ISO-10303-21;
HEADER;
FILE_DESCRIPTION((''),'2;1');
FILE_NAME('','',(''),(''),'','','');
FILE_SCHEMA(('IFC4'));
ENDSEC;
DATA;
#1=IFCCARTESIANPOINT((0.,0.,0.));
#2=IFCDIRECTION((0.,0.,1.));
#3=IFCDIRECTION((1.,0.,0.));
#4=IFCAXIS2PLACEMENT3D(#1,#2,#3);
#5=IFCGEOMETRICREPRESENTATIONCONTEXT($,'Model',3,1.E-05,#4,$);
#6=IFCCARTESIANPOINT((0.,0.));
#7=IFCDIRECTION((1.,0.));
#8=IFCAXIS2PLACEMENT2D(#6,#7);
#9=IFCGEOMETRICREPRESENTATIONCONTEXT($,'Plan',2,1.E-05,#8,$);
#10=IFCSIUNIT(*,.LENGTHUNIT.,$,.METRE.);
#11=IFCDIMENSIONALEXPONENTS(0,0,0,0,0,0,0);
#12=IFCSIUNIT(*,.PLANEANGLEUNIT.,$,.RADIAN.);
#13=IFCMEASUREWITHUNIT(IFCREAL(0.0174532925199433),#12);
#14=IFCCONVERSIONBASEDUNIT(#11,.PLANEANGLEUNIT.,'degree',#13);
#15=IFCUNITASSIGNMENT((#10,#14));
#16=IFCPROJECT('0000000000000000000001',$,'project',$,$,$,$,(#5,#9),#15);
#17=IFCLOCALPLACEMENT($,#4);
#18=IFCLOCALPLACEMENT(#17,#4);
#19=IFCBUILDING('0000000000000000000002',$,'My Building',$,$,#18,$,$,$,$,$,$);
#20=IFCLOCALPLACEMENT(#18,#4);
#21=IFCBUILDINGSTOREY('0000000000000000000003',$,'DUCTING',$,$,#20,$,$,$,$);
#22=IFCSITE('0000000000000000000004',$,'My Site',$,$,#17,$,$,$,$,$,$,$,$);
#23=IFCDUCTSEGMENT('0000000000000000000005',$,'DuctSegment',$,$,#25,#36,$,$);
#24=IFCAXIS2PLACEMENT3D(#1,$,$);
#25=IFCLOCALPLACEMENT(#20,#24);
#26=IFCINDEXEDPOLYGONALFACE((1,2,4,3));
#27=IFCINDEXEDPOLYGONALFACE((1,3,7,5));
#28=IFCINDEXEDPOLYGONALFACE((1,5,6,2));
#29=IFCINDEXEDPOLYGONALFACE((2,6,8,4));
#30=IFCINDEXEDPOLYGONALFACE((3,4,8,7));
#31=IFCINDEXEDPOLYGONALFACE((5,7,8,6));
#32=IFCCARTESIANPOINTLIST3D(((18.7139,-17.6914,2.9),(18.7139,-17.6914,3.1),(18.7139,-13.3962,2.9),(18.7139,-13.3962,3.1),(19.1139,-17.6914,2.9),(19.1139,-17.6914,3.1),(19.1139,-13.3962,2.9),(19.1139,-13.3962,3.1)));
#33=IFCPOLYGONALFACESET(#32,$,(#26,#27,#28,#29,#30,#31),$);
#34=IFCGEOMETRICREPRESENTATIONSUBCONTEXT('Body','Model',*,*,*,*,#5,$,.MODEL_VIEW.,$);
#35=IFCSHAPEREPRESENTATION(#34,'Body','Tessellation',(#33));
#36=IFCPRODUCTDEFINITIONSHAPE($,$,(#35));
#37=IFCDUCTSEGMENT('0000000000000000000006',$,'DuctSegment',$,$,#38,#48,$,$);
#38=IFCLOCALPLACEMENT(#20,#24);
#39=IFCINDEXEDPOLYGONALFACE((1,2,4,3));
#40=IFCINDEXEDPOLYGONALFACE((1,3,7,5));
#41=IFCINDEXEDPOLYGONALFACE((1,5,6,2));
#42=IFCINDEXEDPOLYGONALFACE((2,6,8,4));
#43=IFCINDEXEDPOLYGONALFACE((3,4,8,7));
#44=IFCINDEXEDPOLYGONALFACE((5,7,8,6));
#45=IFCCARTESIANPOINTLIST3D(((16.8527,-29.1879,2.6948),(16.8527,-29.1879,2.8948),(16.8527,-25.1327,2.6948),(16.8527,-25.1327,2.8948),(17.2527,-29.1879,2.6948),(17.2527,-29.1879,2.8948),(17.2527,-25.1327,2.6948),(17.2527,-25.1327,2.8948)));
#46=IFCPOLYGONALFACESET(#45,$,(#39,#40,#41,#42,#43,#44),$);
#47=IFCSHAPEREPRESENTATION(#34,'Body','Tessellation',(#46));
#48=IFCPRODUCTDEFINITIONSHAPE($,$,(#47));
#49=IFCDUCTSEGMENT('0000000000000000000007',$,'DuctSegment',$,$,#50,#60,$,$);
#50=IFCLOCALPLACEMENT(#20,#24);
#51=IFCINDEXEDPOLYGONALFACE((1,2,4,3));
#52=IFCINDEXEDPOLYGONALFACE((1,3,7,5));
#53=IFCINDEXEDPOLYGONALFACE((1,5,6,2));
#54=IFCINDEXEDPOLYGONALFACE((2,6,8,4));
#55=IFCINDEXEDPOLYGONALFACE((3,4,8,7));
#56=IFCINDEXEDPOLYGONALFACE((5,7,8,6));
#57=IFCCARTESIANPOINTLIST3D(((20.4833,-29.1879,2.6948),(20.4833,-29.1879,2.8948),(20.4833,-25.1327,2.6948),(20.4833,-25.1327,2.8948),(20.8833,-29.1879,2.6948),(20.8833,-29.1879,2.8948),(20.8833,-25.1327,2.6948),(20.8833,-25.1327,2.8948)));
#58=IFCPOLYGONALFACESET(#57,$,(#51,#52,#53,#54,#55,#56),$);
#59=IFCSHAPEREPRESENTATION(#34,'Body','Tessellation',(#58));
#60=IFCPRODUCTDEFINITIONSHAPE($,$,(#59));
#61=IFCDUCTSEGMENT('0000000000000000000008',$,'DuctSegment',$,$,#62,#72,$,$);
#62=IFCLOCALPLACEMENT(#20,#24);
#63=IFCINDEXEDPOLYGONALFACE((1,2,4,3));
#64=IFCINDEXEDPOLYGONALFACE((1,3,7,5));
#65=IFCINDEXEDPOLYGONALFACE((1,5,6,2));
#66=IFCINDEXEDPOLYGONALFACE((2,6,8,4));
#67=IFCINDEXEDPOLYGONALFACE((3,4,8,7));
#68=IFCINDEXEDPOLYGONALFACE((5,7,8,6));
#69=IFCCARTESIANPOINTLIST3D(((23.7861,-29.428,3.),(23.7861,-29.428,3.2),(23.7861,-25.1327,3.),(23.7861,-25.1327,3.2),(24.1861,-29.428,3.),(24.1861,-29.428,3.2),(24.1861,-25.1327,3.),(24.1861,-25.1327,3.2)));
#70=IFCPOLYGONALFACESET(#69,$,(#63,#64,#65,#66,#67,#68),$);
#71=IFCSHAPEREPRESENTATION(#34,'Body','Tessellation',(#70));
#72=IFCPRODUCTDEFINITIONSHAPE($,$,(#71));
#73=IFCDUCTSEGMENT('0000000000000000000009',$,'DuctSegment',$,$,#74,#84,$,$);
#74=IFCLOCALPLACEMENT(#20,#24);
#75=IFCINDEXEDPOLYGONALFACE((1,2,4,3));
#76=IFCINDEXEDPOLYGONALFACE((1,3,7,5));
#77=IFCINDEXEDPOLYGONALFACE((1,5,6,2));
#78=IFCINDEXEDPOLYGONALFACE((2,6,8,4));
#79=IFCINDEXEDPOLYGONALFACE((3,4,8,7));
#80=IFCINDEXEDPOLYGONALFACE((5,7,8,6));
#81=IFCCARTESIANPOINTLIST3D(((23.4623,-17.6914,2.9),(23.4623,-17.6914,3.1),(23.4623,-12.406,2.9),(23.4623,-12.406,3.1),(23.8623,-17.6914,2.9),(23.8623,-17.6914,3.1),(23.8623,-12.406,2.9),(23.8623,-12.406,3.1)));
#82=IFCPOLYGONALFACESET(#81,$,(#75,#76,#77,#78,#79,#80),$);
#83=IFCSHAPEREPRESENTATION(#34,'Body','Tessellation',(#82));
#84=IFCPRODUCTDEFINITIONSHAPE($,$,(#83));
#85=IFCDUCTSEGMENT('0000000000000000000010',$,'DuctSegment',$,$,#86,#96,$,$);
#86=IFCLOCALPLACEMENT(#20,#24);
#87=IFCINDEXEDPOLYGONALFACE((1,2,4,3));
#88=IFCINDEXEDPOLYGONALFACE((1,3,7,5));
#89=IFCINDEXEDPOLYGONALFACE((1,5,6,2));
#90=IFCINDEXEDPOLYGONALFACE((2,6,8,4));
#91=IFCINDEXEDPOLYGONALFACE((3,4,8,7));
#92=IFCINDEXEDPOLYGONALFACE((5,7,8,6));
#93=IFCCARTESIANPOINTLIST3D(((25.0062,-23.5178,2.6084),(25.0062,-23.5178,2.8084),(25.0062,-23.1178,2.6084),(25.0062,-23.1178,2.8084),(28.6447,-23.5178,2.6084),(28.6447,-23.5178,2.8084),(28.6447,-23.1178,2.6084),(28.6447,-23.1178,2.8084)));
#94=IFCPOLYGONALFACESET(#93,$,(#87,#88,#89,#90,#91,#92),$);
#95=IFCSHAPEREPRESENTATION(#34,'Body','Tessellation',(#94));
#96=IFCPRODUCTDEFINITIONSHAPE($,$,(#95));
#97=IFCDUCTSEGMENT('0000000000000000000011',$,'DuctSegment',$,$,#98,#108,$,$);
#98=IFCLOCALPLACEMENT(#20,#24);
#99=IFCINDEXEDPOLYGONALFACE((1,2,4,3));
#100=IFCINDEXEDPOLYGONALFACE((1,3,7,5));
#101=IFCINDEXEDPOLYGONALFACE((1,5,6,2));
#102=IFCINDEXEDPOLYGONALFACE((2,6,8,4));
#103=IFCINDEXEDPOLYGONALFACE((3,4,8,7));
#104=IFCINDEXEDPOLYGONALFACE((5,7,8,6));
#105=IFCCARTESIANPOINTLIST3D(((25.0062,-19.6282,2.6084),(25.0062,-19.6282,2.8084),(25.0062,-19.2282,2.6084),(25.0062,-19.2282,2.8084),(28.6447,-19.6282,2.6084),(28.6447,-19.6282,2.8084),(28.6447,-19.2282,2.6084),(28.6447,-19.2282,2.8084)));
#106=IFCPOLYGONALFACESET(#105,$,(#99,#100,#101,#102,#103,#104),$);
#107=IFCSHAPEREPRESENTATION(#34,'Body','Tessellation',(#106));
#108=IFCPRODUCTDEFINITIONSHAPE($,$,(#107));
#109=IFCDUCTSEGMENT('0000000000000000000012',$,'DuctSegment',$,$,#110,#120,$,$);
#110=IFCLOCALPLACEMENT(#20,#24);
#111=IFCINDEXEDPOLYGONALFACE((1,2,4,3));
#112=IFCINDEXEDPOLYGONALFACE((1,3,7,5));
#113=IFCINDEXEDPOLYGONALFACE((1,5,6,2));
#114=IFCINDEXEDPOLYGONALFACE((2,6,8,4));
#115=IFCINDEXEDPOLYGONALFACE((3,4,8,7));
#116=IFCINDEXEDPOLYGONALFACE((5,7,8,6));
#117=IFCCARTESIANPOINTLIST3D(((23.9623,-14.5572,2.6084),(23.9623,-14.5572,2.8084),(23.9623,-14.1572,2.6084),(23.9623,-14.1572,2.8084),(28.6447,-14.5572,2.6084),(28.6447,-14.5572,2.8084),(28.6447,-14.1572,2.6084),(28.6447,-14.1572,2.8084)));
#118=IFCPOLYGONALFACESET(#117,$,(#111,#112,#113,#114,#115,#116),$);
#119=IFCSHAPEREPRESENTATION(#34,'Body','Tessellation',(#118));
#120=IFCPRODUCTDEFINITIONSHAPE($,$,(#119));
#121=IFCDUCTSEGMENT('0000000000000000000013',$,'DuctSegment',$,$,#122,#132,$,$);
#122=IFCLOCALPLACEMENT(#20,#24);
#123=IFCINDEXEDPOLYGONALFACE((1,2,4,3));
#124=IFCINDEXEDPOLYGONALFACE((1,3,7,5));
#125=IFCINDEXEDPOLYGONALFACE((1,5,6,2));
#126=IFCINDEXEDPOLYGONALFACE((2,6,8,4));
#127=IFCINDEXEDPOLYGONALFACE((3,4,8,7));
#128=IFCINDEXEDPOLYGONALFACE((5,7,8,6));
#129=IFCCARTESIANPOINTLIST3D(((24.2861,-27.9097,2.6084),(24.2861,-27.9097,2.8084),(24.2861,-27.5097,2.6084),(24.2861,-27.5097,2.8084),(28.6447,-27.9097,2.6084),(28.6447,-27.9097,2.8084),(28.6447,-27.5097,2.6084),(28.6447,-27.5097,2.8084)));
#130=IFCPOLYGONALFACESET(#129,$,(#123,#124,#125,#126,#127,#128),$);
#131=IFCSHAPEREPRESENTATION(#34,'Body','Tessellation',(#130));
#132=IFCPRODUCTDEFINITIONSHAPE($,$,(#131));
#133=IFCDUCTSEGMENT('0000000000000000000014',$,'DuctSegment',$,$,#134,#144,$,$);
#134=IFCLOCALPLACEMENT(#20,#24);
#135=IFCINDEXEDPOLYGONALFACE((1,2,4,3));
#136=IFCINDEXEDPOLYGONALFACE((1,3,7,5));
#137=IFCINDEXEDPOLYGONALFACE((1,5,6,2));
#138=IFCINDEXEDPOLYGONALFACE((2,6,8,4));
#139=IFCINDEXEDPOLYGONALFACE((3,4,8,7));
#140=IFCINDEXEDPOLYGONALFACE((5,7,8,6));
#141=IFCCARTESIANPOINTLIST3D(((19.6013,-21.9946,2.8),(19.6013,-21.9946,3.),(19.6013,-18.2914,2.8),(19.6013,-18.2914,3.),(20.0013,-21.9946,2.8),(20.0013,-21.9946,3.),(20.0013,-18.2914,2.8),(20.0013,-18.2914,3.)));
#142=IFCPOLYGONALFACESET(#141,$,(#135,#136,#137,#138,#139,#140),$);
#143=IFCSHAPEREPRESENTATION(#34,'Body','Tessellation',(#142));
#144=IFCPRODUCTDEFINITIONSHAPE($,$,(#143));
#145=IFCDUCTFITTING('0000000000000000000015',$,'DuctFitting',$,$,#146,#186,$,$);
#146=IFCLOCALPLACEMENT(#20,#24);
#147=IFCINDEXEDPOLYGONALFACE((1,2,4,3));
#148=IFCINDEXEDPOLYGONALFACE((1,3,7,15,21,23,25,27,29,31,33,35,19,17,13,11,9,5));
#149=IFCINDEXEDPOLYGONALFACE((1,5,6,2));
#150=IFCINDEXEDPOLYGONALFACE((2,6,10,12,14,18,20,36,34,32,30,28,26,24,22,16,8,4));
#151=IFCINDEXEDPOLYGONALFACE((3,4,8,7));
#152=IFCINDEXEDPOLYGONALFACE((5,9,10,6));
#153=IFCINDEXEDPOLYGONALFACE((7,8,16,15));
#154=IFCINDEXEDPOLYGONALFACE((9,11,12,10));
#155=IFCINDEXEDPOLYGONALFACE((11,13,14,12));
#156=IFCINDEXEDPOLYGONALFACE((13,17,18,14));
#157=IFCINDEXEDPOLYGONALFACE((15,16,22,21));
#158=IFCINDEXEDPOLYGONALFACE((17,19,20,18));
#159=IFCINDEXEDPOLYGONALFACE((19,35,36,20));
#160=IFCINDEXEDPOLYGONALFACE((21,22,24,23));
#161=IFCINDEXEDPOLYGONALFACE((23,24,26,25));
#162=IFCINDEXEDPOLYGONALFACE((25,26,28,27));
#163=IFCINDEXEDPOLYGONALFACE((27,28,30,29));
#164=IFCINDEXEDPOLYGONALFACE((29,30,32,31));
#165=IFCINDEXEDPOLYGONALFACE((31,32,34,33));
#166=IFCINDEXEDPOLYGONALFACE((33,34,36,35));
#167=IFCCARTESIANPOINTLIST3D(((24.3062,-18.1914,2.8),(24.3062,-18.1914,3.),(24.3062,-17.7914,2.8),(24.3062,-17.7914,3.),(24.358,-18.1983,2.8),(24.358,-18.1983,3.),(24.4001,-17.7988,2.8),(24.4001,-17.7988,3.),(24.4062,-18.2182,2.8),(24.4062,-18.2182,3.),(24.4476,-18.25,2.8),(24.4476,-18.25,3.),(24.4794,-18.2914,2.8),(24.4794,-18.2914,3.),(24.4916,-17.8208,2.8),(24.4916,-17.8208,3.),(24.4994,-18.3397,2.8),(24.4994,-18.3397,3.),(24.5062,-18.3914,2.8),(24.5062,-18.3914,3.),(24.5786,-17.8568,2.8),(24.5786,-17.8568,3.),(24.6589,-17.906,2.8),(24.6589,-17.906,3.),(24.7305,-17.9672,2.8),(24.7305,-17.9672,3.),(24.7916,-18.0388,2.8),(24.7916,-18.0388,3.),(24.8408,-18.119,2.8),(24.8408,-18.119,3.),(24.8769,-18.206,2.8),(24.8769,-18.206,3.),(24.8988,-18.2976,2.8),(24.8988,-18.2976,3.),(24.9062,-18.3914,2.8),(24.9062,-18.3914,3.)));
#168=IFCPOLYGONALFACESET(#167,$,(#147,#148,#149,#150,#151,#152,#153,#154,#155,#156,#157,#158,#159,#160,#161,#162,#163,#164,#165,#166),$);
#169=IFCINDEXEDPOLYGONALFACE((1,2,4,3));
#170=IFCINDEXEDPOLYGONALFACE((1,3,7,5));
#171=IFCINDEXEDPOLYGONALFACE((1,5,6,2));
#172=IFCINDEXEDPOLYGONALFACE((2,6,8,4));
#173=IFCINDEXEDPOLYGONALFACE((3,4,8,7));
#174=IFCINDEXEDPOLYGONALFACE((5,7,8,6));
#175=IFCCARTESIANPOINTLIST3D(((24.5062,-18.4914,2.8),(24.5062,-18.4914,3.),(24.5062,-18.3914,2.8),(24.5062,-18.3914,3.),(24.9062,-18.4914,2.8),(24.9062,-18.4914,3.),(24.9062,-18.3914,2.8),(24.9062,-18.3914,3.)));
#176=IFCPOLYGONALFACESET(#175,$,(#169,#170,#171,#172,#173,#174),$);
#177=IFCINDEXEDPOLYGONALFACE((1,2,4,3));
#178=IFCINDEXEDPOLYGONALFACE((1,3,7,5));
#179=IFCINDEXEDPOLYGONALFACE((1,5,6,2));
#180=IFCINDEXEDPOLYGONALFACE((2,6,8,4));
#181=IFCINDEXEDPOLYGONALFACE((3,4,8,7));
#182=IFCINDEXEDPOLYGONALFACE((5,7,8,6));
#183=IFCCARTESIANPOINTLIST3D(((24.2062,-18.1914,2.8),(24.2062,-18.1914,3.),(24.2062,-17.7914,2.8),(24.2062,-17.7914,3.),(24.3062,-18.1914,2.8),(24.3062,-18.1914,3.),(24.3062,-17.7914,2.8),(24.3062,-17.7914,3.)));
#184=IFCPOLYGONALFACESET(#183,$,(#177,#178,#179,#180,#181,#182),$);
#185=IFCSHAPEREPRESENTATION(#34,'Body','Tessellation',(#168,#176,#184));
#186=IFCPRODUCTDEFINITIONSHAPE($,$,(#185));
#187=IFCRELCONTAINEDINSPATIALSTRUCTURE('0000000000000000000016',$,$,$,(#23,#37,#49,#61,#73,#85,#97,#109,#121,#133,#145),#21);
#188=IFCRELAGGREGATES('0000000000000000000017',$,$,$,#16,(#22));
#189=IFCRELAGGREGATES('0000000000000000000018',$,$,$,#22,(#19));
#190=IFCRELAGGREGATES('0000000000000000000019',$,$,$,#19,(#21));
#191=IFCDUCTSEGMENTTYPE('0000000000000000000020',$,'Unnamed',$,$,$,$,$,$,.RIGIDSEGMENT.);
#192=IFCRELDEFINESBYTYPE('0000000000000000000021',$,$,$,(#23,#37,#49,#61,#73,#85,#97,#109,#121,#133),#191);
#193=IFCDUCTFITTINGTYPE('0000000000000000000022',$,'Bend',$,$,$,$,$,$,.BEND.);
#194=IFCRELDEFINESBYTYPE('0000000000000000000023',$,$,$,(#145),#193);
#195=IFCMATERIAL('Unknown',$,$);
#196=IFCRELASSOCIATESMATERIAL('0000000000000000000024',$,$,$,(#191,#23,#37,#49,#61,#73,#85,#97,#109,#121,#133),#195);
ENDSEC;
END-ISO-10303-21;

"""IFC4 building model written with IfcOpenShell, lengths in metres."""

from ifc_helpers import new_model, entity, si_unit, converted_unit, frame, origin_with_axes, origin_2d_with_axis, place, context, subcontext, project, spatial, line, arc, indexed_curve, rectangle, outline, extrude, source, transform, mapped, material, material_profile, profile_set, profile_usage, type_object, type_shapes, element, save


model = new_model("IFC4")

# Units and contexts
model_context = context("Model", 3, precision=1e-05, world=origin_with_axes())
plan_context = context("Plan", 2, precision=1e-05, world=origin_2d_with_axis())
body_context = subcontext(model_context, "Body", "Model", "MODEL_VIEW")
ifc_project = project(units=[si_unit("LENGTHUNIT", "METRE"), converted_unit("PLANEANGLEUNIT", "degree", entity("IfcReal", 0.0174532925199433), si_unit("PLANEANGLEUNIT", "RADIAN"), dimensions=[0, 0, 0, 0, 0, 0, 0])], contexts=[model_context, plan_context])

# Site, building, storey
site_placement = place(None, origin_with_axes())
site = spatial("IfcSite", under=ifc_project, at=site_placement, Name="My Site")
building_placement = place(site_placement, origin_with_axes())
building = spatial("IfcBuilding", under=site, at=building_placement, Name="My Building")
storey_placement = place(building_placement, origin_with_axes())
storey = spatial("IfcBuildingStorey", under=building, at=storey_placement, Name="DUCTING")

# Duct segments
ifc_material = material(Name="Unknown")
ifc_material_profile_1 = material_profile(ifc_material, rectangle(XDim=0.4, YDim=0.2))
ifc_profile_set_1 = profile_set([ifc_material_profile_1])
ifc_profile_usage_1 = profile_usage(ifc_profile_set_1, cardinal=5)
duct_segment_type = type_object("IfcDuctSegmentType", Name="Unnamed", PredefinedType="RIGIDSEGMENT", material=ifc_profile_set_1)
duct_segment_1_placement = place(storey_placement, frame((18.9139, -17.6914, 3.0), z_axis=(0.0, 1.0, 0.0), x_axis=(-1.0, 0.0, 0.0)))
element("IfcDuctSegment", 1, at=duct_segment_1_placement, inside=storey, type_object=duct_segment_type, material=ifc_profile_usage_1, Name="DuctSegment", context=body_context, shape_type="SweptSolid", body=[
    extrude(rectangle(XDim=0.4, YDim=0.2), origin_with_axes(), (0.0, 0.0, 1.0), 4.2953),
])
ifc_profile_usage_2 = profile_usage(ifc_profile_set_1, cardinal=5)
duct_segment_2_placement = place(storey_placement, frame((17.0527, -25.1327, 2.7948), z_axis=(0.0, -1.0, 0.0), x_axis=(1.0, 0.0, 0.0)))
element("IfcDuctSegment", 2, at=duct_segment_2_placement, inside=storey, type_object=duct_segment_type, material=ifc_profile_usage_2, Name="DuctSegment", context=body_context, shape_type="SweptSolid", body=[
    extrude(rectangle(XDim=0.4, YDim=0.2), origin_with_axes(), (0.0, 0.0, 1.0), 4.0552),
])
ifc_profile_usage_3 = profile_usage(ifc_profile_set_1, cardinal=5)
duct_segment_3_placement = place(storey_placement, frame((20.6833, -25.1327, 2.7948), z_axis=(0.0, -1.0, 0.0), x_axis=(1.0, 0.0, 0.0)))
element("IfcDuctSegment", 3, at=duct_segment_3_placement, inside=storey, type_object=duct_segment_type, material=ifc_profile_usage_3, Name="DuctSegment", context=body_context, shape_type="SweptSolid", body=[
    extrude(rectangle(XDim=0.4, YDim=0.2), origin_with_axes(), (0.0, 0.0, 1.0), 4.0552),
])
ifc_profile_usage_4 = profile_usage(ifc_profile_set_1, cardinal=5)
duct_segment_4_placement = place(storey_placement, frame((23.9861, -25.1327, 3.1), z_axis=(0.0, -1.0, 0.0), x_axis=(1.0, 0.0, 0.0)))
element("IfcDuctSegment", 4, at=duct_segment_4_placement, inside=storey, type_object=duct_segment_type, material=ifc_profile_usage_4, Name="DuctSegment", context=body_context, shape_type="SweptSolid", body=[
    extrude(rectangle(XDim=0.4, YDim=0.2), origin_with_axes(), (0.0, 0.0, 1.0), 4.2953),
])
ifc_profile_usage_5 = profile_usage(ifc_profile_set_1, cardinal=5)
duct_segment_5_placement = place(storey_placement, frame((23.6623, -17.6914, 3.0), z_axis=(0.0, 1.0, 0.0), x_axis=(-1.0, 0.0, 0.0)))
element("IfcDuctSegment", 5, at=duct_segment_5_placement, inside=storey, type_object=duct_segment_type, material=ifc_profile_usage_5, Name="DuctSegment", context=body_context, shape_type="SweptSolid", body=[
    extrude(rectangle(XDim=0.4, YDim=0.2), origin_with_axes(), (0.0, 0.0, 1.0), 5.2855),
])
ifc_profile_usage_6 = profile_usage(ifc_profile_set_1, cardinal=5)
duct_segment_6_placement = place(storey_placement, frame((25.0062, -23.3178, 2.7084), z_axis=(1.0, 0.0, 0.0), x_axis=(0.0, 1.0, 0.0)))
element("IfcDuctSegment", 6, at=duct_segment_6_placement, inside=storey, type_object=duct_segment_type, material=ifc_profile_usage_6, Name="DuctSegment", context=body_context, shape_type="SweptSolid", body=[
    extrude(rectangle(XDim=0.4, YDim=0.2), origin_with_axes(), (0.0, 0.0, 1.0), 3.6385),
])
ifc_profile_usage_7 = profile_usage(ifc_profile_set_1, cardinal=5)
duct_segment_7_placement = place(storey_placement, frame((25.0062, -19.4282, 2.7084), z_axis=(1.0, 0.0, 0.0), x_axis=(0.0, 1.0, 0.0)))
element("IfcDuctSegment", 7, at=duct_segment_7_placement, inside=storey, type_object=duct_segment_type, material=ifc_profile_usage_7, Name="DuctSegment", context=body_context, shape_type="SweptSolid", body=[
    extrude(rectangle(XDim=0.4, YDim=0.2), origin_with_axes(), (0.0, 0.0, 1.0), 3.6385),
])
ifc_profile_usage_8 = profile_usage(ifc_profile_set_1, cardinal=5)
duct_segment_8_placement = place(storey_placement, frame((23.9623, -14.3572, 2.7084), z_axis=(1.0, 0.0, 0.0), x_axis=(0.0, 1.0, 0.0)))
element("IfcDuctSegment", 8, at=duct_segment_8_placement, inside=storey, type_object=duct_segment_type, material=ifc_profile_usage_8, Name="DuctSegment", context=body_context, shape_type="SweptSolid", body=[
    extrude(rectangle(XDim=0.4, YDim=0.2), origin_with_axes(), (0.0, 0.0, 1.0), 4.6824),
])
ifc_profile_usage_9 = profile_usage(ifc_profile_set_1, cardinal=5)
duct_segment_9_placement = place(storey_placement, frame((24.2861, -27.7097, 2.7084), z_axis=(1.0, -0.000001, 0.0), x_axis=(0.000001, 1.0, 0.0)))
element("IfcDuctSegment", 9, at=duct_segment_9_placement, inside=storey, type_object=duct_segment_type, material=ifc_profile_usage_9, Name="DuctSegment", context=body_context, shape_type="SweptSolid", body=[
    extrude(rectangle(XDim=0.4, YDim=0.2), origin_with_axes(), (0.0, 0.0, 1.0), 4.3586),
])
ifc_profile_usage_10 = profile_usage(ifc_profile_set_1, cardinal=5)
duct_segment_10_placement = place(storey_placement, frame((19.8013, -18.2914, 2.9), z_axis=(0.0, -1.0, 0.0), x_axis=(1.0, 0.0, 0.0)))
element("IfcDuctSegment", 10, at=duct_segment_10_placement, inside=storey, type_object=duct_segment_type, material=ifc_profile_usage_10, Name="DuctSegment", context=body_context, shape_type="SweptSolid", body=[
    extrude(rectangle(XDim=0.4, YDim=0.2), origin_with_axes(), (0.0, 0.0, 1.0), 3.7032),
])

# Duct fitting
duct_fitting_type_1 = type_object("IfcDuctFittingType", Name="Bend", PredefinedType="BEND")
shared_shape = source(origin_with_axes(), body_context, "Body", "SweptSolid", [
    extrude(outline(indexed_curve([(-0.2, 0.0), (-0.2586, -0.1414), (-0.4, -0.2), (-0.4, -0.6), (0.0243, -0.4243), (0.2, 0.0)], segments=[arc(1, 2, 3), line(3, 4), arc(4, 5, 6), line(6, 1)])), frame((0.0, -0.1, -0.1), z_axis=(0.0, -1.0, 0.0), x_axis=(1.0, 0.0, 0.0)), (0.0, 0.0, -1.0), 0.2),
    extrude(rectangle(XDim=0.4, YDim=0.2), origin_with_axes(), (0.0, 0.0, -1.0), 0.1),
    extrude(rectangle(XDim=0.4, YDim=0.2), frame((-0.4, 0.0, -0.5), z_axis=(-1.0, 0.0, 0.0), x_axis=(0.0, 0.0, -1.0)), (0.0, 0.0, 1.0), 0.1),
])
type_shapes(duct_fitting_type_1, [shared_shape])
for number, where, z_axis, x_axis, name in (
    (11, (24.7062, -18.4914, 2.9), (0.0, -1.0, 0.0), (1.0, 0.0, 0.0), "DuctFitting"),
):
    element("IfcDuctFitting", number, at=place(storey_placement, frame(where, z_axis=z_axis, x_axis=x_axis)), inside=storey, type_object=duct_fitting_type_1, Name=name, context=body_context, shape_type="MappedRepresentation", body=[
        mapped(shared_shape, transform((0.0, 0.0, 0.0), x_axis=(1.0, 0.0, 0.0), y_axis=(0.0, 1.0, 0.0), z_axis=(0.0, 0.0, 1.0), scale=1.0)),
    ])

save(model, "model.ifc")
